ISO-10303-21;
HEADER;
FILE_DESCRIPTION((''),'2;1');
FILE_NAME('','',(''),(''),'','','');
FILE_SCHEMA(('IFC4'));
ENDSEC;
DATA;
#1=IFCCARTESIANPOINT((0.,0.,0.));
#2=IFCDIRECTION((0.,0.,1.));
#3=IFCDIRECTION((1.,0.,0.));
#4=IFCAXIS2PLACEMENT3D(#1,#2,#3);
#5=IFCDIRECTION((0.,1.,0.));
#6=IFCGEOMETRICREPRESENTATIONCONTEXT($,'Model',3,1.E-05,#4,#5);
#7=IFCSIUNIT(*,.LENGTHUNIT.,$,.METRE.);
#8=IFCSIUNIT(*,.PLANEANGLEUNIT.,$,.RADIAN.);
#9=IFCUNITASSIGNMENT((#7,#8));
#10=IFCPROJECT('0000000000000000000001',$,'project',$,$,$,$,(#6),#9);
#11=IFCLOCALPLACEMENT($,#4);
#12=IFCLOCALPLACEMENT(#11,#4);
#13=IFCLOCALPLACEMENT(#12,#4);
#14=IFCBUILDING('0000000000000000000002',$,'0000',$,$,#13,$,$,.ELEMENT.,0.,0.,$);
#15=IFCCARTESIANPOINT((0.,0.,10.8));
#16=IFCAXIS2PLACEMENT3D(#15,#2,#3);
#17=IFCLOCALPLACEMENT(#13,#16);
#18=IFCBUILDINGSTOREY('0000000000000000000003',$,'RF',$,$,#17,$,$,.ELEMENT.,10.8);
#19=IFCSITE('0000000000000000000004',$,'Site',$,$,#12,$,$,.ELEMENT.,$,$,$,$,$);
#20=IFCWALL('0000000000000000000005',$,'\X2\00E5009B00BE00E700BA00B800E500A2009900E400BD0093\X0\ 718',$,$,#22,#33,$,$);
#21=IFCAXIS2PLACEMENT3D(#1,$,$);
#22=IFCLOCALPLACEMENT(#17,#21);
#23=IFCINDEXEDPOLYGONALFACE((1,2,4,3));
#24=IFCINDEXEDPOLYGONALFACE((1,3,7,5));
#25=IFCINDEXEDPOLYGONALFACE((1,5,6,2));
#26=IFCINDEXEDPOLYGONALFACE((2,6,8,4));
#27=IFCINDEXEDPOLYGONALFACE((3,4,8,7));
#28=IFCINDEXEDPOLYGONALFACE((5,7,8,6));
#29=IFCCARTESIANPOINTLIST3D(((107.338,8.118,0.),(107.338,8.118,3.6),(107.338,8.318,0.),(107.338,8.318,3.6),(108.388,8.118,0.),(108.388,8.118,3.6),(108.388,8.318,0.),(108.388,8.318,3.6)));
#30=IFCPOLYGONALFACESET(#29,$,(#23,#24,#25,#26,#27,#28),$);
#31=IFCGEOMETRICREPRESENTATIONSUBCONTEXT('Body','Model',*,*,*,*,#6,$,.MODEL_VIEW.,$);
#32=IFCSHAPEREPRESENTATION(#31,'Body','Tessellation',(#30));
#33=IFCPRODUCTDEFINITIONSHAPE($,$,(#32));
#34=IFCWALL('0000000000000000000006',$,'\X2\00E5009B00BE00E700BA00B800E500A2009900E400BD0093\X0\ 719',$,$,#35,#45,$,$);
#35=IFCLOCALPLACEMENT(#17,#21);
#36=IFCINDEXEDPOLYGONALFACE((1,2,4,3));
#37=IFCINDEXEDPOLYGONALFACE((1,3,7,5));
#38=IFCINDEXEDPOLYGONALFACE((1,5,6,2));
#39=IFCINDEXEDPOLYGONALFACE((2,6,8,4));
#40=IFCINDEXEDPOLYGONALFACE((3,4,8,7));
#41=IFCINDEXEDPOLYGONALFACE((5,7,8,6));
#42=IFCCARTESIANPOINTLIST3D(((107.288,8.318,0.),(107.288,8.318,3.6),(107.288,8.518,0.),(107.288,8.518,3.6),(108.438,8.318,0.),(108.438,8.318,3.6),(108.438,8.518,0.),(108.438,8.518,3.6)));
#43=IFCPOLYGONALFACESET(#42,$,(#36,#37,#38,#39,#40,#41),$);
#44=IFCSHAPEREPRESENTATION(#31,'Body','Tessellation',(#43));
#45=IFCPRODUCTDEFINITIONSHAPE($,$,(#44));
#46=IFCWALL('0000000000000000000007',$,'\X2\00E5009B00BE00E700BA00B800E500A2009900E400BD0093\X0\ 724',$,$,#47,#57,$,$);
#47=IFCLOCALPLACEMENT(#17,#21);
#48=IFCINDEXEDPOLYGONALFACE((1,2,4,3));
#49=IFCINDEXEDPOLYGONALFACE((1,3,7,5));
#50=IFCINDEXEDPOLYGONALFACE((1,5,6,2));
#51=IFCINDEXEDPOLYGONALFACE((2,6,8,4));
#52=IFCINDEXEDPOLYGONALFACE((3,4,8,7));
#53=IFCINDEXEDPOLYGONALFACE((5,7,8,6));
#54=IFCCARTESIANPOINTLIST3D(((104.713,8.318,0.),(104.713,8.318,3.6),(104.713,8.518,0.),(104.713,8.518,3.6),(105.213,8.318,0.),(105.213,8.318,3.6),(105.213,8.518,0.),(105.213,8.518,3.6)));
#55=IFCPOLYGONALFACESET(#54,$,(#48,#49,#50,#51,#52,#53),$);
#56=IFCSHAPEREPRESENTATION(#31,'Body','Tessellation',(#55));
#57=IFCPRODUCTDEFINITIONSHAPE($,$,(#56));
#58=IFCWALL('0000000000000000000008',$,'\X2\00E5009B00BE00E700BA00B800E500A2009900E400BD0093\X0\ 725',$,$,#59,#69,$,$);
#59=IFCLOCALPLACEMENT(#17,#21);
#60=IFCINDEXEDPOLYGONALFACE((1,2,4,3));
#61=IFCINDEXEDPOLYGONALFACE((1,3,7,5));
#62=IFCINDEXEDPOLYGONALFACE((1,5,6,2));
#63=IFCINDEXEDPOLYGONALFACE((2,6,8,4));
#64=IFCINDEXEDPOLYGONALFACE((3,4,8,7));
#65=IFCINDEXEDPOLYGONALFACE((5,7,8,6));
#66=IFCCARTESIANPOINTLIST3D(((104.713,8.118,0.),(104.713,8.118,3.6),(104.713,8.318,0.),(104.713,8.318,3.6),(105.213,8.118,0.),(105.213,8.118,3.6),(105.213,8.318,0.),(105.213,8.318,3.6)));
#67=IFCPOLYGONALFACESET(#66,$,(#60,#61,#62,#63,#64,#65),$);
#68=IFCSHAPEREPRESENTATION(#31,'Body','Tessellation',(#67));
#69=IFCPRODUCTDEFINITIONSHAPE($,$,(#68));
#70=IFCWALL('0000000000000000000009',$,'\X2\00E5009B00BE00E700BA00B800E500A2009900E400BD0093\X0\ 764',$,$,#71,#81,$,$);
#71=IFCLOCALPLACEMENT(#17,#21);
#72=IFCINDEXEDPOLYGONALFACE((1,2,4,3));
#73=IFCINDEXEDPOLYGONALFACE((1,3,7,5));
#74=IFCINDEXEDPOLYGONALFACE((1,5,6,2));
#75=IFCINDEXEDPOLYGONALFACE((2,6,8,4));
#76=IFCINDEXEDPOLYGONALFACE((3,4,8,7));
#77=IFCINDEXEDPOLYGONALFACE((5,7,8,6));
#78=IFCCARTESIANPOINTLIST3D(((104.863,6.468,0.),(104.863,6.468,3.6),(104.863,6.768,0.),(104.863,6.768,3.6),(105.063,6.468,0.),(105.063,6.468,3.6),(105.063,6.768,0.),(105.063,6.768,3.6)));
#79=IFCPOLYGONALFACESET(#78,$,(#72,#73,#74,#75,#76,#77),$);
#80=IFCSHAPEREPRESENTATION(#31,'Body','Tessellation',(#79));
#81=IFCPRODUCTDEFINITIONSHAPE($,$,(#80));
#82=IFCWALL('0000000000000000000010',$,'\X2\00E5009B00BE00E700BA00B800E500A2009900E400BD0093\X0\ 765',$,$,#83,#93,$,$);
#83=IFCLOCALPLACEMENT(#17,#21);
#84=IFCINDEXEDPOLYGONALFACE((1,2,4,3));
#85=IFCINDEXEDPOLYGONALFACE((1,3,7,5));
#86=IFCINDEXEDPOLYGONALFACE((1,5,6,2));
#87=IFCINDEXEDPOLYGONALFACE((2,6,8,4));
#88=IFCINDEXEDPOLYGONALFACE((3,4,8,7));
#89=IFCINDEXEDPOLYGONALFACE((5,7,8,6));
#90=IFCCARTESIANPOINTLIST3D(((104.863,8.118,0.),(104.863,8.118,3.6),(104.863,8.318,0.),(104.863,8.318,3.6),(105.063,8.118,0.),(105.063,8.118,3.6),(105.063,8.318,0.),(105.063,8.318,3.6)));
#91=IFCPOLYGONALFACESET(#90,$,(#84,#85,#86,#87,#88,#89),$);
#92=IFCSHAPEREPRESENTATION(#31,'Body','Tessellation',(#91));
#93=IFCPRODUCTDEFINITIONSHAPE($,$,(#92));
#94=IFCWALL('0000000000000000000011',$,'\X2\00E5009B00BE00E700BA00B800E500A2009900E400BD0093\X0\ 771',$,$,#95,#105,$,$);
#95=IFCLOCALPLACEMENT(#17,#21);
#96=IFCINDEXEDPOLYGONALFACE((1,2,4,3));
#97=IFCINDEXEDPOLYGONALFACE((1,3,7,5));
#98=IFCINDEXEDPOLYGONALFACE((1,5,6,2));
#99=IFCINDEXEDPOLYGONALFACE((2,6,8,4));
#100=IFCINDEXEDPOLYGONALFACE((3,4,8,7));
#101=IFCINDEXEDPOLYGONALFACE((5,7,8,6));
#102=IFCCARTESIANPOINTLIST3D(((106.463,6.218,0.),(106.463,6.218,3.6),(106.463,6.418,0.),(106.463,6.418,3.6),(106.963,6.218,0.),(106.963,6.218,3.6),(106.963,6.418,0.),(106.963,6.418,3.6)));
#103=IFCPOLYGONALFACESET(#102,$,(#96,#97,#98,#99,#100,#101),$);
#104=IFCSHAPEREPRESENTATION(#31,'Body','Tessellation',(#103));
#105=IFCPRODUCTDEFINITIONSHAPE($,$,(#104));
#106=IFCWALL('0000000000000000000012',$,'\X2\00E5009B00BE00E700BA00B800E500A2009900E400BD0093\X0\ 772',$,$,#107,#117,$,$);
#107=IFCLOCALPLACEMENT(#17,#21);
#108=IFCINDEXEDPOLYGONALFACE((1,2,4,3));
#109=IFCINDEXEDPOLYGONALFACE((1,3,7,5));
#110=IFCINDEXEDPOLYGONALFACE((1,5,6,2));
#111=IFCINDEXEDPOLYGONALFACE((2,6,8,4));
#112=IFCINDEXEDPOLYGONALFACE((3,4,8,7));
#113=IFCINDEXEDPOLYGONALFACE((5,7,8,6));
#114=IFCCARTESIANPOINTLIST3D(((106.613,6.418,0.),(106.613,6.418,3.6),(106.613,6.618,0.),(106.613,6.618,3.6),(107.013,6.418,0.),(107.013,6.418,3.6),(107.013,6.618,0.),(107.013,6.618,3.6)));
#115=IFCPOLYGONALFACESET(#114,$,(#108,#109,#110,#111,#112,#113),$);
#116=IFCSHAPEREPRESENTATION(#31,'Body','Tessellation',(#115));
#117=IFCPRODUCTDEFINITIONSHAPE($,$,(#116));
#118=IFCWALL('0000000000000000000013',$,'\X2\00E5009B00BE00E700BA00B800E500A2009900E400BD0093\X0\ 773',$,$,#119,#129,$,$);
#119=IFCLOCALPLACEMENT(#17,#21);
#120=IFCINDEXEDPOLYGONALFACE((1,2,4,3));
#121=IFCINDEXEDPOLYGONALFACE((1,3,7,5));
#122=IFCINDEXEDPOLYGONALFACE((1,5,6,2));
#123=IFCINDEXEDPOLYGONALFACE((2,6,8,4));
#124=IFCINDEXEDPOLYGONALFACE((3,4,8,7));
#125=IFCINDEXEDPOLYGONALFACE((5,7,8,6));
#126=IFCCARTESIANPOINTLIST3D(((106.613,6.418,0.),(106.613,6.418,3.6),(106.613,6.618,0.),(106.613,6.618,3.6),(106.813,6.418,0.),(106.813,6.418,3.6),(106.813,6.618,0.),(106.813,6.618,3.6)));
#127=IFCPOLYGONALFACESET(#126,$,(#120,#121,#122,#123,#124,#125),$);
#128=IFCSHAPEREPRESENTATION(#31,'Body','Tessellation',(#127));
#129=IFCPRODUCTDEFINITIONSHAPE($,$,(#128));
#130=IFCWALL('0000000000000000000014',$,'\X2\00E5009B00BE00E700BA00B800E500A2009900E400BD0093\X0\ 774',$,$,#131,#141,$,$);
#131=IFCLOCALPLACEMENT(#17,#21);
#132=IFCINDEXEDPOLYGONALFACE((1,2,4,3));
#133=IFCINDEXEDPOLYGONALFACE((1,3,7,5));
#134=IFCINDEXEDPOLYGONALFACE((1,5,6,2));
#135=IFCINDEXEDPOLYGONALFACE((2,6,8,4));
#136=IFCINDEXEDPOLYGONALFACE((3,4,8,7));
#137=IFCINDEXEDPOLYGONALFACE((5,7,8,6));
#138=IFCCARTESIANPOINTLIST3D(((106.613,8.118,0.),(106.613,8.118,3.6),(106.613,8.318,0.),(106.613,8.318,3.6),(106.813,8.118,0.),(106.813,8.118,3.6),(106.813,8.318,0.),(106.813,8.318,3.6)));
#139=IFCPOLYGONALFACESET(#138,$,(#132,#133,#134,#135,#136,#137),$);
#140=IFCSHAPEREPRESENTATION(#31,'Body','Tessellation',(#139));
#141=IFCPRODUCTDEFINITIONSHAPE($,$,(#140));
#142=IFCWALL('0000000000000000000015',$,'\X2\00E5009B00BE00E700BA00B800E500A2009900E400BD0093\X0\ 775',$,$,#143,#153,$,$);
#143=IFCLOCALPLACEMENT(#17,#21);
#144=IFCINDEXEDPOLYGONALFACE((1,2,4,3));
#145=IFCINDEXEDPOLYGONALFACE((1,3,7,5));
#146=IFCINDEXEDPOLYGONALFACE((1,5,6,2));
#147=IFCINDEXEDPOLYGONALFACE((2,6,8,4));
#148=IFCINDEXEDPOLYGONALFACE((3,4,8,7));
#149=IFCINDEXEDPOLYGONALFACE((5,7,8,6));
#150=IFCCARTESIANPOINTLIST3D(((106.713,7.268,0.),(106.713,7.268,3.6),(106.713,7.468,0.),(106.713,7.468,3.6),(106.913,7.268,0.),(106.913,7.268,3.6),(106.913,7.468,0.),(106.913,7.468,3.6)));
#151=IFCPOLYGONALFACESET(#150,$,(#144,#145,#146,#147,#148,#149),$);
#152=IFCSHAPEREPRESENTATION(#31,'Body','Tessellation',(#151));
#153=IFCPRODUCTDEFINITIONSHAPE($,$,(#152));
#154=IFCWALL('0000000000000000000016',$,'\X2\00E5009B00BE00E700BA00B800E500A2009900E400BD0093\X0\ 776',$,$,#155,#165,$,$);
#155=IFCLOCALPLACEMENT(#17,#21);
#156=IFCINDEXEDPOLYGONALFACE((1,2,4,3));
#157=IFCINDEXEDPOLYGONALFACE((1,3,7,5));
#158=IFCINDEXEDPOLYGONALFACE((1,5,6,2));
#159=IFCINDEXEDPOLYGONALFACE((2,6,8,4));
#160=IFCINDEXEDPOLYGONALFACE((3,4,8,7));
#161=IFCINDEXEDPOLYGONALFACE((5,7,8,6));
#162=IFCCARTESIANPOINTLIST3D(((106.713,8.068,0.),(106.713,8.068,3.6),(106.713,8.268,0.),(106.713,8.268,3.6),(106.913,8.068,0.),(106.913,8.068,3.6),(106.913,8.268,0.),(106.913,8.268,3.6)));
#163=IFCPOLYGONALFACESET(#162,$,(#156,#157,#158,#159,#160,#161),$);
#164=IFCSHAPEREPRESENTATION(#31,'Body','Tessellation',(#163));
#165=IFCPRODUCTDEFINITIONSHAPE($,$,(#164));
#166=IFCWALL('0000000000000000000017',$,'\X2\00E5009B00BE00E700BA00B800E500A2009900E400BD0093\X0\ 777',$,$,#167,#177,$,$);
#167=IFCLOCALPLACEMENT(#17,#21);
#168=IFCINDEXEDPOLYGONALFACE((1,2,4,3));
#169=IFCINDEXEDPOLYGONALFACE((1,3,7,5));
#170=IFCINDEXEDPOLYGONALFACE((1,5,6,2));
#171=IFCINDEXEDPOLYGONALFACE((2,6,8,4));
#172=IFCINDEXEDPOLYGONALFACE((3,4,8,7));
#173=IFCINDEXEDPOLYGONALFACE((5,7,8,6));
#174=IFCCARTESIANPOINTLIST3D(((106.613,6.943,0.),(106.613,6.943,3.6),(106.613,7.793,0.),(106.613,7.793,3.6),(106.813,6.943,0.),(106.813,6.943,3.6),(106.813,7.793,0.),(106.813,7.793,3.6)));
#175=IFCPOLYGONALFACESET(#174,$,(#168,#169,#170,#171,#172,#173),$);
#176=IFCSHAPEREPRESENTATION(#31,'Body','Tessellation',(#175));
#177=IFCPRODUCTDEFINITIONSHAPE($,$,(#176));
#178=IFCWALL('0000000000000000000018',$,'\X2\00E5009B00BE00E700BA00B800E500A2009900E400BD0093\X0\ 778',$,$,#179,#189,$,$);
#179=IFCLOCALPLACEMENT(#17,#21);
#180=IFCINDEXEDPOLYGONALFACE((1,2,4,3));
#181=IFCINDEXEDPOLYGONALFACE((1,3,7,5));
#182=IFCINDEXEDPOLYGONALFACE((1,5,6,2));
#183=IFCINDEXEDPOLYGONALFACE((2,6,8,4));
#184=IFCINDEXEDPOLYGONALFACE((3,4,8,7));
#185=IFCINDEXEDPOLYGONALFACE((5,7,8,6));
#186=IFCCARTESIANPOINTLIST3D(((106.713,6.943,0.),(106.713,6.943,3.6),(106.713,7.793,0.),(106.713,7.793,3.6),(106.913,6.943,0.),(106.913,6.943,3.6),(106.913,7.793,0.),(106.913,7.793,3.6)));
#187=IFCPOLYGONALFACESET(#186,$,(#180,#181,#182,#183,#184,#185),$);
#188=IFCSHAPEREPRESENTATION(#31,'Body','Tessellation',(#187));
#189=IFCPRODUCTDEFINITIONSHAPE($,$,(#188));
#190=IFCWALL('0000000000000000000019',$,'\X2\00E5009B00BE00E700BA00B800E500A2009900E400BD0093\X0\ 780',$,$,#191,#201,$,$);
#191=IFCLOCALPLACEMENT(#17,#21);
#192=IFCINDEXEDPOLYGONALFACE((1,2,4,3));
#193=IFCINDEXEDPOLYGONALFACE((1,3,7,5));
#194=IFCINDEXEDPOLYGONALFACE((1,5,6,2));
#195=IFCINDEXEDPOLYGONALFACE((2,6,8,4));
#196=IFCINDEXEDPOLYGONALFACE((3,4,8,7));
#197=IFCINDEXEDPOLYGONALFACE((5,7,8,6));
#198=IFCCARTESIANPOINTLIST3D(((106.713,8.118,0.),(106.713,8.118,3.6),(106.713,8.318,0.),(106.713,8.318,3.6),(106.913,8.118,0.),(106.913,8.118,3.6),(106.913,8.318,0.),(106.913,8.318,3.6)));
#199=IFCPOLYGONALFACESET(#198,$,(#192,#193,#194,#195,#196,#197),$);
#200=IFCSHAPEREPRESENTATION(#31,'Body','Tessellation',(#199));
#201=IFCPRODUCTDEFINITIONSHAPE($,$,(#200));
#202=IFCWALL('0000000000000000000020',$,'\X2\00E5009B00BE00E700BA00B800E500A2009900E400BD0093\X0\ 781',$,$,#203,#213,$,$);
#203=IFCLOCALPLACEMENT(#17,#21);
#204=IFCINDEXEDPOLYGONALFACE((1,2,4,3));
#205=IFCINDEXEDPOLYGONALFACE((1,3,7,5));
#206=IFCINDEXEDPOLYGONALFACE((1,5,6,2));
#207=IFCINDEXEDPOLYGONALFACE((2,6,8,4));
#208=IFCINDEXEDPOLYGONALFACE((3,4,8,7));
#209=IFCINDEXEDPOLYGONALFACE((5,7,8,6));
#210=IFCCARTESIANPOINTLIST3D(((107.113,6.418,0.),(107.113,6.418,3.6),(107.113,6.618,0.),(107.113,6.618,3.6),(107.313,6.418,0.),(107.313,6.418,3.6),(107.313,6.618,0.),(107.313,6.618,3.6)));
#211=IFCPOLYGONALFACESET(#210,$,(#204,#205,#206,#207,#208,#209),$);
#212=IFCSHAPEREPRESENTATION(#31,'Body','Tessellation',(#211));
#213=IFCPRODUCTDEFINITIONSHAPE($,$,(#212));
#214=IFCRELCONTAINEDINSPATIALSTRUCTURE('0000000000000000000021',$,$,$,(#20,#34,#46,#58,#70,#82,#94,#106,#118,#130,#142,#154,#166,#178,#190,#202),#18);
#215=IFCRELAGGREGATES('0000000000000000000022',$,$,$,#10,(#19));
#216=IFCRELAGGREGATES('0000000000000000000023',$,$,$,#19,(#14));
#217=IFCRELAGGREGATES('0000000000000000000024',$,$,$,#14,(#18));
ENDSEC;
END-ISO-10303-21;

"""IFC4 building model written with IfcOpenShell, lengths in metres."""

from ifc_helpers import new_model, si_unit, direction, frame, frame_2d, origin_with_axes, place, context, subcontext, project, spatial, rectangle, extrude, element, save


model = new_model("IFC4")

# Units and contexts
model_context = context("Model", 3, precision=1e-05, world=origin_with_axes(), true_north=direction((0.0, 1.0, 0.0)))
body_context = subcontext(model_context, "Body", "Model", "MODEL_VIEW")
ifc_project = project(units=[si_unit("LENGTHUNIT", "METRE"), si_unit("PLANEANGLEUNIT", "RADIAN")], contexts=[model_context])

# Site, building, storey
placement = place(None, origin_with_axes())
site_placement = place(placement, origin_with_axes())
site = spatial("IfcSite", under=ifc_project, at=site_placement, Name="Site", CompositionType="ELEMENT")
building_placement = place(site_placement, origin_with_axes())
building = spatial("IfcBuilding", under=site, at=building_placement, Name="0000", CompositionType="ELEMENT", ElevationOfRefHeight=0.0, ElevationOfTerrain=0.0)
storey_placement = place(building_placement, frame((0.0, 0.0, 10.8), z_axis=(0.0, 0.0, 1.0), x_axis=(1.0, 0.0, 0.0)))
storey = spatial("IfcBuildingStorey", under=building, at=storey_placement, Name="RF", CompositionType="ELEMENT", Elevation=10.8)

# Walls
wall_1_placement = place(storey_placement, frame((107.863, 8.218, 0.0), z_axis=(0.0, 0.0, 1.0), x_axis=(-1.0, 0.0, 0.0)))
element("IfcWall", 1, at=wall_1_placement, inside=storey, Name="å\u009b¾çº¸å¢\u0099ä½\u0093 718", context=body_context, shape_type="SweptSolid", body=[
    extrude(rectangle(XDim=1.05, YDim=0.2, at=frame_2d((0.0, 0.0), x_axis=(1.0, 0.0, 0.0))), frame((0.0, 0.0, 0.0), z_axis=(0.0, 0.0, 1.0)), (0.0, 0.0, 1.0), 3.6),
])
wall_2_placement = place(storey_placement, frame((107.863, 8.418, 0.0), z_axis=(0.0, 0.0, 1.0), x_axis=(-1.0, 0.0, 0.0)))
element("IfcWall", 2, at=wall_2_placement, inside=storey, Name="å\u009b¾çº¸å¢\u0099ä½\u0093 719", context=body_context, shape_type="SweptSolid", body=[
    extrude(rectangle(XDim=1.15, YDim=0.2, at=frame_2d((0.0, 0.0), x_axis=(1.0, 0.0, 0.0))), frame((0.0, 0.0, 0.0), z_axis=(0.0, 0.0, 1.0)), (0.0, 0.0, 1.0), 3.6),
])
for number, where, z_axis, x_axis, name in (
    (3, (104.963, 8.418, 0.0), (0.0, 0.0, 1.0), (-1.0, 0.0, 0.0), "å\u009b¾çº¸å¢\u0099ä½\u0093 724"),
    (4, (104.963, 8.218, 0.0), (0.0, 0.0, 1.0), (-1.0, 0.0, 0.0), "å\u009b¾çº¸å¢\u0099ä½\u0093 725"),
):
    element("IfcWall", number, at=place(storey_placement, frame(where, z_axis=z_axis, x_axis=x_axis)), inside=storey, Name=name, context=body_context, shape_type="SweptSolid", body=[
        extrude(rectangle(XDim=0.5, YDim=0.2, at=frame_2d((0.0, 0.0), x_axis=(1.0, 0.0, 0.0))), frame((0.0, 0.0, 0.0), z_axis=(0.0, 0.0, 1.0)), (0.0, 0.0, 1.0), 3.6),
    ])
wall_3_placement = place(storey_placement, frame((104.963, 6.618, 0.0), z_axis=(0.0, 0.0, 1.0), x_axis=(0.0, -1.0, 0.0)))
element("IfcWall", 5, at=wall_3_placement, inside=storey, Name="å\u009b¾çº¸å¢\u0099ä½\u0093 764", context=body_context, shape_type="SweptSolid", body=[
    extrude(rectangle(XDim=0.3, YDim=0.2, at=frame_2d((0.0, 0.0), x_axis=(1.0, 0.0, 0.0))), frame((0.0, 0.0, 0.0), z_axis=(0.0, 0.0, 1.0)), (0.0, 0.0, 1.0), 3.6),
])
wall_4_placement = place(storey_placement, frame((104.963, 8.218, 0.0), z_axis=(0.0, 0.0, 1.0), x_axis=(0.0, 1.0, 0.0)))
element("IfcWall", 6, at=wall_4_placement, inside=storey, Name="å\u009b¾çº¸å¢\u0099ä½\u0093 765", context=body_context, shape_type="SweptSolid", body=[
    extrude(rectangle(XDim=0.2, YDim=0.2, at=frame_2d((0.0, 0.0), x_axis=(1.0, 0.0, 0.0))), frame((0.0, 0.0, 0.0), z_axis=(0.0, 0.0, 1.0)), (0.0, 0.0, 1.0), 3.6),
])
wall_5_placement = place(storey_placement, frame((106.713, 6.318, 0.0), z_axis=(0.0, 0.0, 1.0), x_axis=(1.0, 0.0, 0.0)))
element("IfcWall", 7, at=wall_5_placement, inside=storey, Name="å\u009b¾çº¸å¢\u0099ä½\u0093 771", context=body_context, shape_type="SweptSolid", body=[
    extrude(rectangle(XDim=0.5, YDim=0.2, at=frame_2d((0.0, 0.0), x_axis=(1.0, 0.0, 0.0))), frame((0.0, 0.0, 0.0), z_axis=(0.0, 0.0, 1.0)), (0.0, 0.0, 1.0), 3.6),
])
wall_6_placement = place(storey_placement, frame((106.813, 6.518, 0.0), z_axis=(0.0, 0.0, 1.0), x_axis=(1.0, 0.0, 0.0)))
element("IfcWall", 8, at=wall_6_placement, inside=storey, Name="å\u009b¾çº¸å¢\u0099ä½\u0093 772", context=body_context, shape_type="SweptSolid", body=[
    extrude(rectangle(XDim=0.4, YDim=0.2, at=frame_2d((0.0, 0.0), x_axis=(1.0, 0.0, 0.0))), frame((0.0, 0.0, 0.0), z_axis=(0.0, 0.0, 1.0)), (0.0, 0.0, 1.0), 3.6),
])
for number, where, z_axis, x_axis, name in (
    (9, (106.713, 6.518, 0.0), (0.0, 0.0, 1.0), (0.0, -1.0, 0.0), "å\u009b¾çº¸å¢\u0099ä½\u0093 773"),
    (10, (106.713, 8.218, 0.0), (0.0, 0.0, 1.0), (0.0, 1.0, 0.0), "å\u009b¾çº¸å¢\u0099ä½\u0093 774"),
    (11, (106.813, 7.368, 0.0), (0.0, 0.0, 1.0), (-1.0, 0.0, 0.0), "å\u009b¾çº¸å¢\u0099ä½\u0093 775"),
    (12, (106.813, 8.168, 0.0), (0.0, 0.0, 1.0), (-1.0, 0.0, 0.0), "å\u009b¾çº¸å¢\u0099ä½\u0093 776"),
):
    element("IfcWall", number, at=place(storey_placement, frame(where, z_axis=z_axis, x_axis=x_axis)), inside=storey, Name=name, context=body_context, shape_type="SweptSolid", body=[
        extrude(rectangle(XDim=0.2, YDim=0.2, at=frame_2d((0.0, 0.0), x_axis=(1.0, 0.0, 0.0))), frame((0.0, 0.0, 0.0), z_axis=(0.0, 0.0, 1.0)), (0.0, 0.0, 1.0), 3.6),
    ])
for number, where, z_axis, x_axis, name in (
    (13, (106.713, 7.368, 0.0), (0.0, 0.0, 1.0), (0.0, -1.0, 0.0), "å\u009b¾çº¸å¢\u0099ä½\u0093 777"),
    (14, (106.813, 7.368, 0.0), (0.0, 0.0, 1.0), (0.0, -1.0, 0.0), "å\u009b¾çº¸å¢\u0099ä½\u0093 778"),
):
    element("IfcWall", number, at=place(storey_placement, frame(where, z_axis=z_axis, x_axis=x_axis)), inside=storey, Name=name, context=body_context, shape_type="SweptSolid", body=[
        extrude(rectangle(XDim=0.85, YDim=0.2, at=frame_2d((0.0, 0.0), x_axis=(1.0, 0.0, 0.0))), frame((0.0, 0.0, 0.0), z_axis=(0.0, 0.0, 1.0)), (0.0, 0.0, 1.0), 3.6),
    ])
for number, where, z_axis, x_axis, name in (
    (15, (106.813, 8.218, 0.0), (0.0, 0.0, 1.0), (0.0, -1.0, 0.0), "å\u009b¾çº¸å¢\u0099ä½\u0093 780"),
    (16, (107.213, 6.518, 0.0), (0.0, 0.0, 1.0), (0.0, -1.0, 0.0), "å\u009b¾çº¸å¢\u0099ä½\u0093 781"),
):
    element("IfcWall", number, at=place(storey_placement, frame(where, z_axis=z_axis, x_axis=x_axis)), inside=storey, Name=name, context=body_context, shape_type="SweptSolid", body=[
        extrude(rectangle(XDim=0.2, YDim=0.2, at=frame_2d((0.0, 0.0), x_axis=(1.0, 0.0, 0.0))), frame((0.0, 0.0, 0.0), z_axis=(0.0, 0.0, 1.0)), (0.0, 0.0, 1.0), 3.6),
    ])

save(model, "model.ifc")
